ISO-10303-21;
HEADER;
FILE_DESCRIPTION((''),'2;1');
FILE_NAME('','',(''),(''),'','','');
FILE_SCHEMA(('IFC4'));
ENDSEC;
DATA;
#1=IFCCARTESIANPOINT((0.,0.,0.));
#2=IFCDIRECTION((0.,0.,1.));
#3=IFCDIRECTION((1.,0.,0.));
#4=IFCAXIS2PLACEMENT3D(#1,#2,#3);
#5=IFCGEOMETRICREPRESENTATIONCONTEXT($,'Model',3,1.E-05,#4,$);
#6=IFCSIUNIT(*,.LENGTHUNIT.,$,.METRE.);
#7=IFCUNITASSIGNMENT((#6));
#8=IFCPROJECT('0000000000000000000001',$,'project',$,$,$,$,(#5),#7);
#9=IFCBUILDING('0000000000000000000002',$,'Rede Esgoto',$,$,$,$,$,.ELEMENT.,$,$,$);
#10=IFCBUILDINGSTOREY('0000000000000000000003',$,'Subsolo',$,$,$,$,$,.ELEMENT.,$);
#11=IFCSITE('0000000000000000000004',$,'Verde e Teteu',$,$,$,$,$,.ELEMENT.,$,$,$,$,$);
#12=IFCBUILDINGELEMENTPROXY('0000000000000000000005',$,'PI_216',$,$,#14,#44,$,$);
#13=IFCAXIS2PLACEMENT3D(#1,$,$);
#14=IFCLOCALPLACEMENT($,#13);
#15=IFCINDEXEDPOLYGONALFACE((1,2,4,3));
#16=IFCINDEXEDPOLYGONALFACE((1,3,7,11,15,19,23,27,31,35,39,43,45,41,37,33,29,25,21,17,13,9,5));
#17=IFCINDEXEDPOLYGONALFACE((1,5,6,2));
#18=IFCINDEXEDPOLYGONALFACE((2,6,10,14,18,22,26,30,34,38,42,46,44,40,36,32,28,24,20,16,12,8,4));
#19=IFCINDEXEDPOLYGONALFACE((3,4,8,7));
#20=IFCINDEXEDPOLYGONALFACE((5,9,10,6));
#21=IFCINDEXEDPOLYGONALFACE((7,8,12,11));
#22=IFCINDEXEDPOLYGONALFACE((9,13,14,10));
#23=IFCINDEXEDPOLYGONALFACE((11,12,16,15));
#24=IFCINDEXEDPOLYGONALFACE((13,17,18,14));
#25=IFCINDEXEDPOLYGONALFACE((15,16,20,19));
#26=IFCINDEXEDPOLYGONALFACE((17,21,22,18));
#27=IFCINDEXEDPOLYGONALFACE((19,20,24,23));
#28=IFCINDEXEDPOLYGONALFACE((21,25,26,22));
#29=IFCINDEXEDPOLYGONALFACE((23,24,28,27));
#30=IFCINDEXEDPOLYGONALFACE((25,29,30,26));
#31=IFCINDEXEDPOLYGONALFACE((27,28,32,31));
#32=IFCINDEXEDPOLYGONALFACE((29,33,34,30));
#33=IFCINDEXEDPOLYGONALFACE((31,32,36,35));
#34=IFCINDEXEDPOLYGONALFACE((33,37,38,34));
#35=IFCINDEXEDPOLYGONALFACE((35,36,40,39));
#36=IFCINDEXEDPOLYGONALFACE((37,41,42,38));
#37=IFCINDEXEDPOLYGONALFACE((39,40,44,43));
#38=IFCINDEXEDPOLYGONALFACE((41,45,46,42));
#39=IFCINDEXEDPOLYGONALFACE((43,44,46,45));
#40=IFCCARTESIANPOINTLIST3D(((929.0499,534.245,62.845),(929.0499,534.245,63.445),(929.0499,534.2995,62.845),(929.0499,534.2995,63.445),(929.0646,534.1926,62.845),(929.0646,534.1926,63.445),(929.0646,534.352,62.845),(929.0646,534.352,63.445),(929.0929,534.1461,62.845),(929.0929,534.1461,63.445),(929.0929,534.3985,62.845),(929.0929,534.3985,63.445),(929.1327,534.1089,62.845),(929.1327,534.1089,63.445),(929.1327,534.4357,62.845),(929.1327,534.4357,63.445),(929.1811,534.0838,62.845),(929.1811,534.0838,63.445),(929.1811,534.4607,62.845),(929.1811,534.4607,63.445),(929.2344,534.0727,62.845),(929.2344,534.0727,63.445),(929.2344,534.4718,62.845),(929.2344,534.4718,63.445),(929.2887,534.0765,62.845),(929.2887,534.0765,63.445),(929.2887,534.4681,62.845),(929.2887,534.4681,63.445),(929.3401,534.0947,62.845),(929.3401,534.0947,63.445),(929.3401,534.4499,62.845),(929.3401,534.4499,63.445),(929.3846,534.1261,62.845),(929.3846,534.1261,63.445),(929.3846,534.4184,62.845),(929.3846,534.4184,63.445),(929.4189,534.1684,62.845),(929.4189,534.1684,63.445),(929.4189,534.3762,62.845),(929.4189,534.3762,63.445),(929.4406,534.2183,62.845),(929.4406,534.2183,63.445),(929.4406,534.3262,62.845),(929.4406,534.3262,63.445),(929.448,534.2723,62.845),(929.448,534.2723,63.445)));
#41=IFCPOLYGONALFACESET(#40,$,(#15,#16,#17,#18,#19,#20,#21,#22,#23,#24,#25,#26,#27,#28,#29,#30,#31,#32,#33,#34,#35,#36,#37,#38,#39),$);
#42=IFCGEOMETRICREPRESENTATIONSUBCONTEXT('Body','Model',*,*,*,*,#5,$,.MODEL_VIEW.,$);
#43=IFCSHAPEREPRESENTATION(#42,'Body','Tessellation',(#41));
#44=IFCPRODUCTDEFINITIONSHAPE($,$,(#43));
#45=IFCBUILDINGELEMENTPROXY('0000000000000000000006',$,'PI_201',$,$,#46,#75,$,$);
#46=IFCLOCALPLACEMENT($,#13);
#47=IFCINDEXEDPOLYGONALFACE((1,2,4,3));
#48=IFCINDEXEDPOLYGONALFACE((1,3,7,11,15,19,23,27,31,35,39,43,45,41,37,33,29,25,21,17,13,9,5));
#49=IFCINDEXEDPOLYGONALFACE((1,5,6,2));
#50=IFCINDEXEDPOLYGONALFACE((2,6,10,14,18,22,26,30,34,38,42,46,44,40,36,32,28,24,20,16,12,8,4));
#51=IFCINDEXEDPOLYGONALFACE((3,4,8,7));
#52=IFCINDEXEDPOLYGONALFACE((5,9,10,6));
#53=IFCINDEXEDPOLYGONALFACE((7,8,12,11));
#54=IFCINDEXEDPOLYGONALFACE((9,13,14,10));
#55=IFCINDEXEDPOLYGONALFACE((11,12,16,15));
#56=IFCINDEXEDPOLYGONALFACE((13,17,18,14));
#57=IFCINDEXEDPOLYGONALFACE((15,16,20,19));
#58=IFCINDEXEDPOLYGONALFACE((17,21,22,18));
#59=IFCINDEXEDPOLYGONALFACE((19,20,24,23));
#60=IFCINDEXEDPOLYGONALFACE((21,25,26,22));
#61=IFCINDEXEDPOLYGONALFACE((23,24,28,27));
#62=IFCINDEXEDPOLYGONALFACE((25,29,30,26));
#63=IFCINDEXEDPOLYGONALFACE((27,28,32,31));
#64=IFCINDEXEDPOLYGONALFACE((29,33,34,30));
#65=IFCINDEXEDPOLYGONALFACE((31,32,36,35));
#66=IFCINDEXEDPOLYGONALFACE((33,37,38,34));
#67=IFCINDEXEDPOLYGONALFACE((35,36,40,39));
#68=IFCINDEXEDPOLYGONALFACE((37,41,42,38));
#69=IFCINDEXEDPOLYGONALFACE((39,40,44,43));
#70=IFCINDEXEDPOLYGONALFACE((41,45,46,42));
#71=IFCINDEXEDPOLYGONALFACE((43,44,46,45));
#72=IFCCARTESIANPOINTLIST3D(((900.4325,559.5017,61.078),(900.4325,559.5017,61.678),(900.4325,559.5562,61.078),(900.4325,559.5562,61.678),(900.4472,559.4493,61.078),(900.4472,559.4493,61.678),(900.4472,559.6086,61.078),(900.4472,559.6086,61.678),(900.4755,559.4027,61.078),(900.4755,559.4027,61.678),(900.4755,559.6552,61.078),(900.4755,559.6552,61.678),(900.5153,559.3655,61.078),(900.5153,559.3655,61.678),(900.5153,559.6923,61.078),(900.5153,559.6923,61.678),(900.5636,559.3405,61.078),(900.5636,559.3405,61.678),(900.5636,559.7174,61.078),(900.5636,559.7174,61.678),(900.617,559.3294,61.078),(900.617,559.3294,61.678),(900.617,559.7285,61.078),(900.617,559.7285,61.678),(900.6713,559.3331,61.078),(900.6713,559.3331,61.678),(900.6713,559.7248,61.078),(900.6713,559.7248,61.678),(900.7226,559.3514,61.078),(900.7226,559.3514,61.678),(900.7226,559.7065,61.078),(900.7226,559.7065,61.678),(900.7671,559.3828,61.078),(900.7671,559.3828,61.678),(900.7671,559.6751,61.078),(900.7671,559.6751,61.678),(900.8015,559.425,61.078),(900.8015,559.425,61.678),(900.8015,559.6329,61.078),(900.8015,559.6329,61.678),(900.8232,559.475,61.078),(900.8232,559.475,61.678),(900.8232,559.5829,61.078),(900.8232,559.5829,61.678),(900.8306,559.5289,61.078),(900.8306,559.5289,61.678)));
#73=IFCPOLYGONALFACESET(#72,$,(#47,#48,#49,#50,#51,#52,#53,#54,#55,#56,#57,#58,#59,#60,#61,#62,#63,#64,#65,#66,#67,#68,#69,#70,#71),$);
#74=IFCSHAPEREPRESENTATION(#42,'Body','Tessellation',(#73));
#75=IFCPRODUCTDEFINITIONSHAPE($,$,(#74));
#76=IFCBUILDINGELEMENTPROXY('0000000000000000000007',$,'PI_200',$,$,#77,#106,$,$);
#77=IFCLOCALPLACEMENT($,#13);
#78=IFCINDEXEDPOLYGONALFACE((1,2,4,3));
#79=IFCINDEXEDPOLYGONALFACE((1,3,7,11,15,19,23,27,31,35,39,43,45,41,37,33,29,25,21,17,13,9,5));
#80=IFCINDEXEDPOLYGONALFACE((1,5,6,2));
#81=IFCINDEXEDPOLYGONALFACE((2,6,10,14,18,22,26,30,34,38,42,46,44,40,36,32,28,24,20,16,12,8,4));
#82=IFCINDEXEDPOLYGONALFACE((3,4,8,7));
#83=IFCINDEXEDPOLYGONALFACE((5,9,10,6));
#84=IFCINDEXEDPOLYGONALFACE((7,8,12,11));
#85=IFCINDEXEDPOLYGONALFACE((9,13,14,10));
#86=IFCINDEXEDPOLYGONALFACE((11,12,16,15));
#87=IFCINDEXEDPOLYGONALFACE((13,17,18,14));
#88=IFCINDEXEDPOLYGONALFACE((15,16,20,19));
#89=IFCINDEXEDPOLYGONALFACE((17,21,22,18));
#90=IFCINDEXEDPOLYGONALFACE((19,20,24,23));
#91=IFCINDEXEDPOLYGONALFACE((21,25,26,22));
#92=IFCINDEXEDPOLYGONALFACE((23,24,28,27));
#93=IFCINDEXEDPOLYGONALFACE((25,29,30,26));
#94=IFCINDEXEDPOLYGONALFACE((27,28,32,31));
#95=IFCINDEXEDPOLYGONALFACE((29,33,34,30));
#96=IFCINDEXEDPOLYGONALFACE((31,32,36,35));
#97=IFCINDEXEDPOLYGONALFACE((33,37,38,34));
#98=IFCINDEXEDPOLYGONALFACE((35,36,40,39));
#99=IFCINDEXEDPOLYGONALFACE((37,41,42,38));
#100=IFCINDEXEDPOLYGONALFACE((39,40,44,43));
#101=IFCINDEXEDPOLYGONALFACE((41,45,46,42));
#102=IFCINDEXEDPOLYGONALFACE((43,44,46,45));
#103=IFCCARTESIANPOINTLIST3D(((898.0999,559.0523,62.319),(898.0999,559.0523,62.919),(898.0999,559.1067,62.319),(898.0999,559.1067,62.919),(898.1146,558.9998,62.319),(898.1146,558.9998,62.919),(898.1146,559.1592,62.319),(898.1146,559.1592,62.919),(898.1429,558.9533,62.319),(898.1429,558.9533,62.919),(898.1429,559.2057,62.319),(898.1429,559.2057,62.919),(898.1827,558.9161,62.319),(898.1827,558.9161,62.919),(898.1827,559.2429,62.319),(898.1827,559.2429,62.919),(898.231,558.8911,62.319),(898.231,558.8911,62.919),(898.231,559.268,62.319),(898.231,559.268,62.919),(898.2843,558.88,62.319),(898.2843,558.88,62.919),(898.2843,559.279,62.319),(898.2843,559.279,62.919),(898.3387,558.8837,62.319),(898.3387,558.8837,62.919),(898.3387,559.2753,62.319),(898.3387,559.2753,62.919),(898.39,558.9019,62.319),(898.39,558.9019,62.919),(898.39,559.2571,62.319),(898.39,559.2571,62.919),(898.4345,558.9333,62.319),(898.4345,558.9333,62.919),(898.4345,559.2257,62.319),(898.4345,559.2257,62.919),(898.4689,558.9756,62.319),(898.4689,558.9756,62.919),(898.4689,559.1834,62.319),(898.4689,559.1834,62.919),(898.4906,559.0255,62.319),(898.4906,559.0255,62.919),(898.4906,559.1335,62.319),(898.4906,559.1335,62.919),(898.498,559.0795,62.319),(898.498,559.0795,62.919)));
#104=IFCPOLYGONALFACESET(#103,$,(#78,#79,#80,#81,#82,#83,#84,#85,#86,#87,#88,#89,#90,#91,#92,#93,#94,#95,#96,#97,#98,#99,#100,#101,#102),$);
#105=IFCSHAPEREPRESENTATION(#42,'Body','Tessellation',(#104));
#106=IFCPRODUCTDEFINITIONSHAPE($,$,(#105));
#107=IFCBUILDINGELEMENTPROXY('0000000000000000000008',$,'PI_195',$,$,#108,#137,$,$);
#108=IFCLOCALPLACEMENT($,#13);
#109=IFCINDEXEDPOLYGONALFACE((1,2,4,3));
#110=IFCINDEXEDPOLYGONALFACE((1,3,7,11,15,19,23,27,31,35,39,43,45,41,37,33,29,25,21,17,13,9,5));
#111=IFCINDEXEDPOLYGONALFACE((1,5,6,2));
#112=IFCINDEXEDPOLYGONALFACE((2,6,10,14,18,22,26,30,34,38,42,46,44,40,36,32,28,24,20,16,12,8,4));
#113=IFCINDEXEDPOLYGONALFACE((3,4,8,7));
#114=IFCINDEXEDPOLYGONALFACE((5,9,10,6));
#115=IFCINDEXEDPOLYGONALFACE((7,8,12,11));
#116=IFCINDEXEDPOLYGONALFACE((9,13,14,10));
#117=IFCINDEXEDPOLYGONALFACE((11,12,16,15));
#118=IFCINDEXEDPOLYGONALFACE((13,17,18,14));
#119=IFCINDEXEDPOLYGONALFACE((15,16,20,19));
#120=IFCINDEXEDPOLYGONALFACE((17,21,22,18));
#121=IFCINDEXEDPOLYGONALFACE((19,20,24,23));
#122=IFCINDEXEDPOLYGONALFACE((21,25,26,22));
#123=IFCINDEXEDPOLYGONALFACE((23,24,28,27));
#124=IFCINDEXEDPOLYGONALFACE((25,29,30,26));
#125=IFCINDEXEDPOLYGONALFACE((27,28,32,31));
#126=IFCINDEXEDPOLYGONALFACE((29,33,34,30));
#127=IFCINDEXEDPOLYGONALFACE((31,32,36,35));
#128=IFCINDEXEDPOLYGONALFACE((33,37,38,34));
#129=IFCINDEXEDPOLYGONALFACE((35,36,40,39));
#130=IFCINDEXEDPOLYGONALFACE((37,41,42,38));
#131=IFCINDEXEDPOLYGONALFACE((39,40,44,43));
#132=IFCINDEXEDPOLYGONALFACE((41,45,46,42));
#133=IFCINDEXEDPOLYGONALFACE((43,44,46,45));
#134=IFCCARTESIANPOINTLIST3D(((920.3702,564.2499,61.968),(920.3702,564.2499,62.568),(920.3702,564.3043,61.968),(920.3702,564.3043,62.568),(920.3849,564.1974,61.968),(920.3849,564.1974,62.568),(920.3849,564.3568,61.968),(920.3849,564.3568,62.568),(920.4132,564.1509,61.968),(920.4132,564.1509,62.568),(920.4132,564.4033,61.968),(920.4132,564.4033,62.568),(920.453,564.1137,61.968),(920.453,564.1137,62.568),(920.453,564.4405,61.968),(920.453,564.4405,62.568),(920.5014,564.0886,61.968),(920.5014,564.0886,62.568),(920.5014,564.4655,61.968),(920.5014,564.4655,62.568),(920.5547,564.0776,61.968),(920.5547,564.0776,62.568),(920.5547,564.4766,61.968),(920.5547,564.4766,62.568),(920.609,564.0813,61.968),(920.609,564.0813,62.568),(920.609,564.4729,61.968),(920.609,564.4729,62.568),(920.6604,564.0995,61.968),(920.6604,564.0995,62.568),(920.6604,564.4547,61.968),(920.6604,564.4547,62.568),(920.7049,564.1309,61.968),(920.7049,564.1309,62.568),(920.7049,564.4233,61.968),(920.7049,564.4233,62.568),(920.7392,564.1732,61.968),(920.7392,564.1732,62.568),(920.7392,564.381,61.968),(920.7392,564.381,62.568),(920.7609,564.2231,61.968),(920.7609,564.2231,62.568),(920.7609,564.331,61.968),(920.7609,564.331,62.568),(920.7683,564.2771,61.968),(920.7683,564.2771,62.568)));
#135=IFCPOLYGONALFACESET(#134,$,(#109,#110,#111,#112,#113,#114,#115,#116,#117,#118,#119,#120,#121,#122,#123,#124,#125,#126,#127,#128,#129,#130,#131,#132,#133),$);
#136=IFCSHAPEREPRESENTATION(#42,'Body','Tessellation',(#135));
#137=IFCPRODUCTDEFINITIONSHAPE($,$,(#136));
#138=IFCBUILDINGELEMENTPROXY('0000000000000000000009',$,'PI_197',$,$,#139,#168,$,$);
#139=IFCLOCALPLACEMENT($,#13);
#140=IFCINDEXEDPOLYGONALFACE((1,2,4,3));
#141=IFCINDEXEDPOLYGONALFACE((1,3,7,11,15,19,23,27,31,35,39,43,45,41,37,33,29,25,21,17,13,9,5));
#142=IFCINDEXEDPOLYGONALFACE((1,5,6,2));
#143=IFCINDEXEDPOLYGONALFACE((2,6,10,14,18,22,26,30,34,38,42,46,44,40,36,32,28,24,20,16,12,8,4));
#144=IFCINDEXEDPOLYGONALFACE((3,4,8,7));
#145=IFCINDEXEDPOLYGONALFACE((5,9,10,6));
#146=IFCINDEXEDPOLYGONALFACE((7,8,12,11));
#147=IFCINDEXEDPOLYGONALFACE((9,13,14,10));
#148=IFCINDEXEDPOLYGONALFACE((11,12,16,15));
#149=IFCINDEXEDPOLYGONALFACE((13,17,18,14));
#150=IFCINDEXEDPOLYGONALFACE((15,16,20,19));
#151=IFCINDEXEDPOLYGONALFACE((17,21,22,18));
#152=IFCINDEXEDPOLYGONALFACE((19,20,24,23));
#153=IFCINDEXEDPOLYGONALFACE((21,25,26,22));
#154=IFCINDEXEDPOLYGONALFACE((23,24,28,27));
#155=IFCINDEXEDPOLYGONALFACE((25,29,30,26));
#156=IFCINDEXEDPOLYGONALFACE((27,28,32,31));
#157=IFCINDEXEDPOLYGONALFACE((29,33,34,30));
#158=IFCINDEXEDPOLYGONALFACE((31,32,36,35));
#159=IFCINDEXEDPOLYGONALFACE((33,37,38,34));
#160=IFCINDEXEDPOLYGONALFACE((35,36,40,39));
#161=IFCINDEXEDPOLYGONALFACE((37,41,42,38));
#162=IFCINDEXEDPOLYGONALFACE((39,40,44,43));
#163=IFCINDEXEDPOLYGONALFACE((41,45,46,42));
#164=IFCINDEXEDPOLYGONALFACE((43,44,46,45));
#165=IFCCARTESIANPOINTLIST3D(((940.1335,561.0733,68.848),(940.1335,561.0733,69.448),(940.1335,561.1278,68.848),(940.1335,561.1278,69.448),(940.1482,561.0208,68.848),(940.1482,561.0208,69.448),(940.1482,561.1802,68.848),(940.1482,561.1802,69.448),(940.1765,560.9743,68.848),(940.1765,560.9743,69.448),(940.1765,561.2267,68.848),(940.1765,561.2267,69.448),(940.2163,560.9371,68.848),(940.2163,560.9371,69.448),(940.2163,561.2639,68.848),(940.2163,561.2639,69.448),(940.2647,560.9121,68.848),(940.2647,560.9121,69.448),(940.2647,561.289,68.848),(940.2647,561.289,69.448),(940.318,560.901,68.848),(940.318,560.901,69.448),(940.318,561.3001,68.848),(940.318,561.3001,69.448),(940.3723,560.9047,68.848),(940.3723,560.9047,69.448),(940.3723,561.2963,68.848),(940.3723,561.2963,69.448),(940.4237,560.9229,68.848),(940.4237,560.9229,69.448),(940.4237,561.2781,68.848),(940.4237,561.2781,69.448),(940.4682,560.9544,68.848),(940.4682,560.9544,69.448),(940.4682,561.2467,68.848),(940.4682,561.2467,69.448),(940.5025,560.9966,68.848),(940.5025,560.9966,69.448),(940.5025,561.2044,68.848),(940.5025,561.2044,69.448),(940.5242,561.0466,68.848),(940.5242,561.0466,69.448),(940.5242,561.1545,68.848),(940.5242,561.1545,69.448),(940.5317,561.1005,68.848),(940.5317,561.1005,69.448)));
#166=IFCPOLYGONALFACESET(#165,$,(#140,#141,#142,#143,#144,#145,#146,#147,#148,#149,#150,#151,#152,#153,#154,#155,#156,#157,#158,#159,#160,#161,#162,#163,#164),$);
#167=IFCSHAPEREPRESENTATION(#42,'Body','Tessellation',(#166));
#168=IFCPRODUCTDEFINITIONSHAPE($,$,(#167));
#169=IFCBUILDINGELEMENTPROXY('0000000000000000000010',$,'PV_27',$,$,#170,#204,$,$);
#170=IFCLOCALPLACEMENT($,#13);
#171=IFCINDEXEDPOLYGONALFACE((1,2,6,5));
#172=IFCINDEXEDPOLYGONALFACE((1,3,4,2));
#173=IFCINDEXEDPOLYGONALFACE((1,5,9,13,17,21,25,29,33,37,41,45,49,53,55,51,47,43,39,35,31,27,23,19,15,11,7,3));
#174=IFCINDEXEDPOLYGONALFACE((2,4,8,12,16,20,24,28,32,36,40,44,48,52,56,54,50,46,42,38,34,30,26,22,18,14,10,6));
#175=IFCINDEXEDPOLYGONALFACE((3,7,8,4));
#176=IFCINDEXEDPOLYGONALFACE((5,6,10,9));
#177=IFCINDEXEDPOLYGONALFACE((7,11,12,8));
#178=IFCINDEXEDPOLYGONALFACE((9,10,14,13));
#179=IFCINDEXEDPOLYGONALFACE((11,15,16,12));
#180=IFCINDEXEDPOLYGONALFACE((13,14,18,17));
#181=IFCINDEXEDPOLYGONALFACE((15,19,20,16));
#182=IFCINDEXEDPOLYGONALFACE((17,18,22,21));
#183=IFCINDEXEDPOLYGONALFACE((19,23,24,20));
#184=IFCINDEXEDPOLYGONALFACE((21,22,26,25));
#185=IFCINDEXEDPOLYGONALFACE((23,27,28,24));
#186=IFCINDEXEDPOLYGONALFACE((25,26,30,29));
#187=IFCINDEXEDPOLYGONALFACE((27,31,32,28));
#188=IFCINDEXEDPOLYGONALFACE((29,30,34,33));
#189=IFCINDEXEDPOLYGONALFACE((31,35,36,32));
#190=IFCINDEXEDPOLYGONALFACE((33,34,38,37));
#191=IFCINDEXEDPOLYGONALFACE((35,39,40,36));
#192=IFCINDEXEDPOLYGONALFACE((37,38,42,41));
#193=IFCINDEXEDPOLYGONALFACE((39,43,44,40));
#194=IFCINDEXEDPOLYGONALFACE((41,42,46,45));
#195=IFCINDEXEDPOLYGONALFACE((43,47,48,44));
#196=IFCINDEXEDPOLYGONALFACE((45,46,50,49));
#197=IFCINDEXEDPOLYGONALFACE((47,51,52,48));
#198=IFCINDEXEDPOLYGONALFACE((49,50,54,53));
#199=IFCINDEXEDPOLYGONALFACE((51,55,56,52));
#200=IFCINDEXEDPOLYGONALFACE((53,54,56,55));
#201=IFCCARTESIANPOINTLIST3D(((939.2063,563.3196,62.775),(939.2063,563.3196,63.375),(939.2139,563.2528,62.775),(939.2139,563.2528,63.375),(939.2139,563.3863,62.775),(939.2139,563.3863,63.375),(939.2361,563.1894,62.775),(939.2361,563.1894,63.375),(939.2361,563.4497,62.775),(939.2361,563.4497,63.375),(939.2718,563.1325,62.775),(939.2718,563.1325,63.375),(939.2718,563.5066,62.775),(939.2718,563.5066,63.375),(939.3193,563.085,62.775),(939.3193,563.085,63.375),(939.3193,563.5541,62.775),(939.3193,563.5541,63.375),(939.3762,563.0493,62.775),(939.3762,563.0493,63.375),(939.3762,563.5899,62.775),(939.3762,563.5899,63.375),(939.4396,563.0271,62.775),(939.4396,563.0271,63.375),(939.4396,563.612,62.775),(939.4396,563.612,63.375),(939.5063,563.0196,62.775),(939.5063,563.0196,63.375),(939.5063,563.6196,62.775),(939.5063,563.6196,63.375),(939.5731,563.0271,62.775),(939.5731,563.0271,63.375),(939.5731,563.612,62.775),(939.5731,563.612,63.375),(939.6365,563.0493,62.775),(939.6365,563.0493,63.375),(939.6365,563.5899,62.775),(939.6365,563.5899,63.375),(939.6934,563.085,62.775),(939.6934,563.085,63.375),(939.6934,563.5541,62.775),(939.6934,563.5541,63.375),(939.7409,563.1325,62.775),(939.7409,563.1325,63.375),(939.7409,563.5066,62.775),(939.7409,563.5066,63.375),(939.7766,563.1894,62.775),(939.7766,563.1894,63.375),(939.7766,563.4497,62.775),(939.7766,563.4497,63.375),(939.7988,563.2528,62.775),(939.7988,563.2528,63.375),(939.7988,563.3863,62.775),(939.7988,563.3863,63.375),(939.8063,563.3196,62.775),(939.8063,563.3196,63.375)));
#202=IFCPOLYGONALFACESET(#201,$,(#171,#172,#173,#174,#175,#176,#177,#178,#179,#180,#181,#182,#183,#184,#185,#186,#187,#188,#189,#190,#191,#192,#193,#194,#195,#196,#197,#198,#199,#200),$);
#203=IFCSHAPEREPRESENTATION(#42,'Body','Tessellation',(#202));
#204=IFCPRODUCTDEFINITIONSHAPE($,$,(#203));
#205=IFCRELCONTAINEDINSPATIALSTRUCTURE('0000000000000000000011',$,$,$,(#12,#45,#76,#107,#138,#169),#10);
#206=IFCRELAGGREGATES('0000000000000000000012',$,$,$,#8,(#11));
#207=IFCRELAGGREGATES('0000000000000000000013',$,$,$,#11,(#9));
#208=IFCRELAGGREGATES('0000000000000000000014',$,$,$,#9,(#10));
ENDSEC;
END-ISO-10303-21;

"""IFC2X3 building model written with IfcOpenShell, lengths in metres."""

from ifc_helpers import new_model, si_unit, frame, origin_with_axes, origin_2d, place, context, subcontext, project, spatial, circle, extrude, element, save


model = new_model("IFC2X3")

# Units and contexts
model_context = context("Model", 3, precision=1e-05, world=origin_with_axes())
body_context = subcontext(model_context, "Body", "Model", "MODEL_VIEW")
ifc_project = project(units=[si_unit("LENGTHUNIT", "METRE")], contexts=[model_context])

# Site, building, storey
site = spatial("IfcSite", under=ifc_project, Name="Verde e Teteu", CompositionType="ELEMENT")
building = spatial("IfcBuilding", under=site, Name="Rede Esgoto", CompositionType="ELEMENT")
storey = spatial("IfcBuildingStorey", under=building, Name="Subsolo", CompositionType="ELEMENT")

# Building element proxies
for number, where, z_axis, x_axis, name in (
    (1, (929.248, 534.2723, 62.845), (0.0, 0.0, 1.0), (1.0, 0.0, 0.0), "PI_216"),
):
    element("IfcBuildingElementProxy", number, at=place(None, frame(where, z_axis=z_axis, x_axis=x_axis)), inside=storey, Name=name, context=body_context, shape_type="SweptSolid", body=[
        extrude(circle(Radius=0.2, at=origin_2d()), origin_with_axes(), (0.0, 0.0, 1.0), 0.6),
    ])
for number, where, z_axis, x_axis, name in (
    (2, (900.6306, 559.5289, 61.078), (0.0, 0.0, 1.0), (1.0, 0.0, 0.0), "PI_201"),
    (3, (898.298, 559.0795, 62.319), (0.0, 0.0, 1.0), (1.0, 0.0, 0.0), "PI_200"),
    (4, (920.5683, 564.2771, 61.968), (0.0, 0.0, 1.0), (1.0, 0.0, 0.0), "PI_195"),
    (5, (940.3317, 561.1005, 68.848), (0.0, 0.0, 1.0), (1.0, 0.0, 0.0), "PI_197"),
):
    element("IfcBuildingElementProxy", number, at=place(None, frame(where, z_axis=z_axis, x_axis=x_axis)), inside=storey, Name=name, context=body_context, shape_type="SweptSolid", body=[
        extrude(circle(Radius=0.2, at=origin_2d()), origin_with_axes(), (0.0, 0.0, 1.0), 0.6),
    ])
proxy_1_placement = place(None, frame((939.5063, 563.3196, 62.775), z_axis=(0.0, 0.0, 1.0), x_axis=(1.0, 0.0, 0.0)))
element("IfcBuildingElementProxy", 6, at=proxy_1_placement, inside=storey, Name="PV_27", context=body_context, shape_type="SweptSolid", body=[
    extrude(circle(Radius=0.3, at=origin_2d()), origin_with_axes(), (0.0, 0.0, 1.0), 0.6),
])

save(model, "model.ifc")
